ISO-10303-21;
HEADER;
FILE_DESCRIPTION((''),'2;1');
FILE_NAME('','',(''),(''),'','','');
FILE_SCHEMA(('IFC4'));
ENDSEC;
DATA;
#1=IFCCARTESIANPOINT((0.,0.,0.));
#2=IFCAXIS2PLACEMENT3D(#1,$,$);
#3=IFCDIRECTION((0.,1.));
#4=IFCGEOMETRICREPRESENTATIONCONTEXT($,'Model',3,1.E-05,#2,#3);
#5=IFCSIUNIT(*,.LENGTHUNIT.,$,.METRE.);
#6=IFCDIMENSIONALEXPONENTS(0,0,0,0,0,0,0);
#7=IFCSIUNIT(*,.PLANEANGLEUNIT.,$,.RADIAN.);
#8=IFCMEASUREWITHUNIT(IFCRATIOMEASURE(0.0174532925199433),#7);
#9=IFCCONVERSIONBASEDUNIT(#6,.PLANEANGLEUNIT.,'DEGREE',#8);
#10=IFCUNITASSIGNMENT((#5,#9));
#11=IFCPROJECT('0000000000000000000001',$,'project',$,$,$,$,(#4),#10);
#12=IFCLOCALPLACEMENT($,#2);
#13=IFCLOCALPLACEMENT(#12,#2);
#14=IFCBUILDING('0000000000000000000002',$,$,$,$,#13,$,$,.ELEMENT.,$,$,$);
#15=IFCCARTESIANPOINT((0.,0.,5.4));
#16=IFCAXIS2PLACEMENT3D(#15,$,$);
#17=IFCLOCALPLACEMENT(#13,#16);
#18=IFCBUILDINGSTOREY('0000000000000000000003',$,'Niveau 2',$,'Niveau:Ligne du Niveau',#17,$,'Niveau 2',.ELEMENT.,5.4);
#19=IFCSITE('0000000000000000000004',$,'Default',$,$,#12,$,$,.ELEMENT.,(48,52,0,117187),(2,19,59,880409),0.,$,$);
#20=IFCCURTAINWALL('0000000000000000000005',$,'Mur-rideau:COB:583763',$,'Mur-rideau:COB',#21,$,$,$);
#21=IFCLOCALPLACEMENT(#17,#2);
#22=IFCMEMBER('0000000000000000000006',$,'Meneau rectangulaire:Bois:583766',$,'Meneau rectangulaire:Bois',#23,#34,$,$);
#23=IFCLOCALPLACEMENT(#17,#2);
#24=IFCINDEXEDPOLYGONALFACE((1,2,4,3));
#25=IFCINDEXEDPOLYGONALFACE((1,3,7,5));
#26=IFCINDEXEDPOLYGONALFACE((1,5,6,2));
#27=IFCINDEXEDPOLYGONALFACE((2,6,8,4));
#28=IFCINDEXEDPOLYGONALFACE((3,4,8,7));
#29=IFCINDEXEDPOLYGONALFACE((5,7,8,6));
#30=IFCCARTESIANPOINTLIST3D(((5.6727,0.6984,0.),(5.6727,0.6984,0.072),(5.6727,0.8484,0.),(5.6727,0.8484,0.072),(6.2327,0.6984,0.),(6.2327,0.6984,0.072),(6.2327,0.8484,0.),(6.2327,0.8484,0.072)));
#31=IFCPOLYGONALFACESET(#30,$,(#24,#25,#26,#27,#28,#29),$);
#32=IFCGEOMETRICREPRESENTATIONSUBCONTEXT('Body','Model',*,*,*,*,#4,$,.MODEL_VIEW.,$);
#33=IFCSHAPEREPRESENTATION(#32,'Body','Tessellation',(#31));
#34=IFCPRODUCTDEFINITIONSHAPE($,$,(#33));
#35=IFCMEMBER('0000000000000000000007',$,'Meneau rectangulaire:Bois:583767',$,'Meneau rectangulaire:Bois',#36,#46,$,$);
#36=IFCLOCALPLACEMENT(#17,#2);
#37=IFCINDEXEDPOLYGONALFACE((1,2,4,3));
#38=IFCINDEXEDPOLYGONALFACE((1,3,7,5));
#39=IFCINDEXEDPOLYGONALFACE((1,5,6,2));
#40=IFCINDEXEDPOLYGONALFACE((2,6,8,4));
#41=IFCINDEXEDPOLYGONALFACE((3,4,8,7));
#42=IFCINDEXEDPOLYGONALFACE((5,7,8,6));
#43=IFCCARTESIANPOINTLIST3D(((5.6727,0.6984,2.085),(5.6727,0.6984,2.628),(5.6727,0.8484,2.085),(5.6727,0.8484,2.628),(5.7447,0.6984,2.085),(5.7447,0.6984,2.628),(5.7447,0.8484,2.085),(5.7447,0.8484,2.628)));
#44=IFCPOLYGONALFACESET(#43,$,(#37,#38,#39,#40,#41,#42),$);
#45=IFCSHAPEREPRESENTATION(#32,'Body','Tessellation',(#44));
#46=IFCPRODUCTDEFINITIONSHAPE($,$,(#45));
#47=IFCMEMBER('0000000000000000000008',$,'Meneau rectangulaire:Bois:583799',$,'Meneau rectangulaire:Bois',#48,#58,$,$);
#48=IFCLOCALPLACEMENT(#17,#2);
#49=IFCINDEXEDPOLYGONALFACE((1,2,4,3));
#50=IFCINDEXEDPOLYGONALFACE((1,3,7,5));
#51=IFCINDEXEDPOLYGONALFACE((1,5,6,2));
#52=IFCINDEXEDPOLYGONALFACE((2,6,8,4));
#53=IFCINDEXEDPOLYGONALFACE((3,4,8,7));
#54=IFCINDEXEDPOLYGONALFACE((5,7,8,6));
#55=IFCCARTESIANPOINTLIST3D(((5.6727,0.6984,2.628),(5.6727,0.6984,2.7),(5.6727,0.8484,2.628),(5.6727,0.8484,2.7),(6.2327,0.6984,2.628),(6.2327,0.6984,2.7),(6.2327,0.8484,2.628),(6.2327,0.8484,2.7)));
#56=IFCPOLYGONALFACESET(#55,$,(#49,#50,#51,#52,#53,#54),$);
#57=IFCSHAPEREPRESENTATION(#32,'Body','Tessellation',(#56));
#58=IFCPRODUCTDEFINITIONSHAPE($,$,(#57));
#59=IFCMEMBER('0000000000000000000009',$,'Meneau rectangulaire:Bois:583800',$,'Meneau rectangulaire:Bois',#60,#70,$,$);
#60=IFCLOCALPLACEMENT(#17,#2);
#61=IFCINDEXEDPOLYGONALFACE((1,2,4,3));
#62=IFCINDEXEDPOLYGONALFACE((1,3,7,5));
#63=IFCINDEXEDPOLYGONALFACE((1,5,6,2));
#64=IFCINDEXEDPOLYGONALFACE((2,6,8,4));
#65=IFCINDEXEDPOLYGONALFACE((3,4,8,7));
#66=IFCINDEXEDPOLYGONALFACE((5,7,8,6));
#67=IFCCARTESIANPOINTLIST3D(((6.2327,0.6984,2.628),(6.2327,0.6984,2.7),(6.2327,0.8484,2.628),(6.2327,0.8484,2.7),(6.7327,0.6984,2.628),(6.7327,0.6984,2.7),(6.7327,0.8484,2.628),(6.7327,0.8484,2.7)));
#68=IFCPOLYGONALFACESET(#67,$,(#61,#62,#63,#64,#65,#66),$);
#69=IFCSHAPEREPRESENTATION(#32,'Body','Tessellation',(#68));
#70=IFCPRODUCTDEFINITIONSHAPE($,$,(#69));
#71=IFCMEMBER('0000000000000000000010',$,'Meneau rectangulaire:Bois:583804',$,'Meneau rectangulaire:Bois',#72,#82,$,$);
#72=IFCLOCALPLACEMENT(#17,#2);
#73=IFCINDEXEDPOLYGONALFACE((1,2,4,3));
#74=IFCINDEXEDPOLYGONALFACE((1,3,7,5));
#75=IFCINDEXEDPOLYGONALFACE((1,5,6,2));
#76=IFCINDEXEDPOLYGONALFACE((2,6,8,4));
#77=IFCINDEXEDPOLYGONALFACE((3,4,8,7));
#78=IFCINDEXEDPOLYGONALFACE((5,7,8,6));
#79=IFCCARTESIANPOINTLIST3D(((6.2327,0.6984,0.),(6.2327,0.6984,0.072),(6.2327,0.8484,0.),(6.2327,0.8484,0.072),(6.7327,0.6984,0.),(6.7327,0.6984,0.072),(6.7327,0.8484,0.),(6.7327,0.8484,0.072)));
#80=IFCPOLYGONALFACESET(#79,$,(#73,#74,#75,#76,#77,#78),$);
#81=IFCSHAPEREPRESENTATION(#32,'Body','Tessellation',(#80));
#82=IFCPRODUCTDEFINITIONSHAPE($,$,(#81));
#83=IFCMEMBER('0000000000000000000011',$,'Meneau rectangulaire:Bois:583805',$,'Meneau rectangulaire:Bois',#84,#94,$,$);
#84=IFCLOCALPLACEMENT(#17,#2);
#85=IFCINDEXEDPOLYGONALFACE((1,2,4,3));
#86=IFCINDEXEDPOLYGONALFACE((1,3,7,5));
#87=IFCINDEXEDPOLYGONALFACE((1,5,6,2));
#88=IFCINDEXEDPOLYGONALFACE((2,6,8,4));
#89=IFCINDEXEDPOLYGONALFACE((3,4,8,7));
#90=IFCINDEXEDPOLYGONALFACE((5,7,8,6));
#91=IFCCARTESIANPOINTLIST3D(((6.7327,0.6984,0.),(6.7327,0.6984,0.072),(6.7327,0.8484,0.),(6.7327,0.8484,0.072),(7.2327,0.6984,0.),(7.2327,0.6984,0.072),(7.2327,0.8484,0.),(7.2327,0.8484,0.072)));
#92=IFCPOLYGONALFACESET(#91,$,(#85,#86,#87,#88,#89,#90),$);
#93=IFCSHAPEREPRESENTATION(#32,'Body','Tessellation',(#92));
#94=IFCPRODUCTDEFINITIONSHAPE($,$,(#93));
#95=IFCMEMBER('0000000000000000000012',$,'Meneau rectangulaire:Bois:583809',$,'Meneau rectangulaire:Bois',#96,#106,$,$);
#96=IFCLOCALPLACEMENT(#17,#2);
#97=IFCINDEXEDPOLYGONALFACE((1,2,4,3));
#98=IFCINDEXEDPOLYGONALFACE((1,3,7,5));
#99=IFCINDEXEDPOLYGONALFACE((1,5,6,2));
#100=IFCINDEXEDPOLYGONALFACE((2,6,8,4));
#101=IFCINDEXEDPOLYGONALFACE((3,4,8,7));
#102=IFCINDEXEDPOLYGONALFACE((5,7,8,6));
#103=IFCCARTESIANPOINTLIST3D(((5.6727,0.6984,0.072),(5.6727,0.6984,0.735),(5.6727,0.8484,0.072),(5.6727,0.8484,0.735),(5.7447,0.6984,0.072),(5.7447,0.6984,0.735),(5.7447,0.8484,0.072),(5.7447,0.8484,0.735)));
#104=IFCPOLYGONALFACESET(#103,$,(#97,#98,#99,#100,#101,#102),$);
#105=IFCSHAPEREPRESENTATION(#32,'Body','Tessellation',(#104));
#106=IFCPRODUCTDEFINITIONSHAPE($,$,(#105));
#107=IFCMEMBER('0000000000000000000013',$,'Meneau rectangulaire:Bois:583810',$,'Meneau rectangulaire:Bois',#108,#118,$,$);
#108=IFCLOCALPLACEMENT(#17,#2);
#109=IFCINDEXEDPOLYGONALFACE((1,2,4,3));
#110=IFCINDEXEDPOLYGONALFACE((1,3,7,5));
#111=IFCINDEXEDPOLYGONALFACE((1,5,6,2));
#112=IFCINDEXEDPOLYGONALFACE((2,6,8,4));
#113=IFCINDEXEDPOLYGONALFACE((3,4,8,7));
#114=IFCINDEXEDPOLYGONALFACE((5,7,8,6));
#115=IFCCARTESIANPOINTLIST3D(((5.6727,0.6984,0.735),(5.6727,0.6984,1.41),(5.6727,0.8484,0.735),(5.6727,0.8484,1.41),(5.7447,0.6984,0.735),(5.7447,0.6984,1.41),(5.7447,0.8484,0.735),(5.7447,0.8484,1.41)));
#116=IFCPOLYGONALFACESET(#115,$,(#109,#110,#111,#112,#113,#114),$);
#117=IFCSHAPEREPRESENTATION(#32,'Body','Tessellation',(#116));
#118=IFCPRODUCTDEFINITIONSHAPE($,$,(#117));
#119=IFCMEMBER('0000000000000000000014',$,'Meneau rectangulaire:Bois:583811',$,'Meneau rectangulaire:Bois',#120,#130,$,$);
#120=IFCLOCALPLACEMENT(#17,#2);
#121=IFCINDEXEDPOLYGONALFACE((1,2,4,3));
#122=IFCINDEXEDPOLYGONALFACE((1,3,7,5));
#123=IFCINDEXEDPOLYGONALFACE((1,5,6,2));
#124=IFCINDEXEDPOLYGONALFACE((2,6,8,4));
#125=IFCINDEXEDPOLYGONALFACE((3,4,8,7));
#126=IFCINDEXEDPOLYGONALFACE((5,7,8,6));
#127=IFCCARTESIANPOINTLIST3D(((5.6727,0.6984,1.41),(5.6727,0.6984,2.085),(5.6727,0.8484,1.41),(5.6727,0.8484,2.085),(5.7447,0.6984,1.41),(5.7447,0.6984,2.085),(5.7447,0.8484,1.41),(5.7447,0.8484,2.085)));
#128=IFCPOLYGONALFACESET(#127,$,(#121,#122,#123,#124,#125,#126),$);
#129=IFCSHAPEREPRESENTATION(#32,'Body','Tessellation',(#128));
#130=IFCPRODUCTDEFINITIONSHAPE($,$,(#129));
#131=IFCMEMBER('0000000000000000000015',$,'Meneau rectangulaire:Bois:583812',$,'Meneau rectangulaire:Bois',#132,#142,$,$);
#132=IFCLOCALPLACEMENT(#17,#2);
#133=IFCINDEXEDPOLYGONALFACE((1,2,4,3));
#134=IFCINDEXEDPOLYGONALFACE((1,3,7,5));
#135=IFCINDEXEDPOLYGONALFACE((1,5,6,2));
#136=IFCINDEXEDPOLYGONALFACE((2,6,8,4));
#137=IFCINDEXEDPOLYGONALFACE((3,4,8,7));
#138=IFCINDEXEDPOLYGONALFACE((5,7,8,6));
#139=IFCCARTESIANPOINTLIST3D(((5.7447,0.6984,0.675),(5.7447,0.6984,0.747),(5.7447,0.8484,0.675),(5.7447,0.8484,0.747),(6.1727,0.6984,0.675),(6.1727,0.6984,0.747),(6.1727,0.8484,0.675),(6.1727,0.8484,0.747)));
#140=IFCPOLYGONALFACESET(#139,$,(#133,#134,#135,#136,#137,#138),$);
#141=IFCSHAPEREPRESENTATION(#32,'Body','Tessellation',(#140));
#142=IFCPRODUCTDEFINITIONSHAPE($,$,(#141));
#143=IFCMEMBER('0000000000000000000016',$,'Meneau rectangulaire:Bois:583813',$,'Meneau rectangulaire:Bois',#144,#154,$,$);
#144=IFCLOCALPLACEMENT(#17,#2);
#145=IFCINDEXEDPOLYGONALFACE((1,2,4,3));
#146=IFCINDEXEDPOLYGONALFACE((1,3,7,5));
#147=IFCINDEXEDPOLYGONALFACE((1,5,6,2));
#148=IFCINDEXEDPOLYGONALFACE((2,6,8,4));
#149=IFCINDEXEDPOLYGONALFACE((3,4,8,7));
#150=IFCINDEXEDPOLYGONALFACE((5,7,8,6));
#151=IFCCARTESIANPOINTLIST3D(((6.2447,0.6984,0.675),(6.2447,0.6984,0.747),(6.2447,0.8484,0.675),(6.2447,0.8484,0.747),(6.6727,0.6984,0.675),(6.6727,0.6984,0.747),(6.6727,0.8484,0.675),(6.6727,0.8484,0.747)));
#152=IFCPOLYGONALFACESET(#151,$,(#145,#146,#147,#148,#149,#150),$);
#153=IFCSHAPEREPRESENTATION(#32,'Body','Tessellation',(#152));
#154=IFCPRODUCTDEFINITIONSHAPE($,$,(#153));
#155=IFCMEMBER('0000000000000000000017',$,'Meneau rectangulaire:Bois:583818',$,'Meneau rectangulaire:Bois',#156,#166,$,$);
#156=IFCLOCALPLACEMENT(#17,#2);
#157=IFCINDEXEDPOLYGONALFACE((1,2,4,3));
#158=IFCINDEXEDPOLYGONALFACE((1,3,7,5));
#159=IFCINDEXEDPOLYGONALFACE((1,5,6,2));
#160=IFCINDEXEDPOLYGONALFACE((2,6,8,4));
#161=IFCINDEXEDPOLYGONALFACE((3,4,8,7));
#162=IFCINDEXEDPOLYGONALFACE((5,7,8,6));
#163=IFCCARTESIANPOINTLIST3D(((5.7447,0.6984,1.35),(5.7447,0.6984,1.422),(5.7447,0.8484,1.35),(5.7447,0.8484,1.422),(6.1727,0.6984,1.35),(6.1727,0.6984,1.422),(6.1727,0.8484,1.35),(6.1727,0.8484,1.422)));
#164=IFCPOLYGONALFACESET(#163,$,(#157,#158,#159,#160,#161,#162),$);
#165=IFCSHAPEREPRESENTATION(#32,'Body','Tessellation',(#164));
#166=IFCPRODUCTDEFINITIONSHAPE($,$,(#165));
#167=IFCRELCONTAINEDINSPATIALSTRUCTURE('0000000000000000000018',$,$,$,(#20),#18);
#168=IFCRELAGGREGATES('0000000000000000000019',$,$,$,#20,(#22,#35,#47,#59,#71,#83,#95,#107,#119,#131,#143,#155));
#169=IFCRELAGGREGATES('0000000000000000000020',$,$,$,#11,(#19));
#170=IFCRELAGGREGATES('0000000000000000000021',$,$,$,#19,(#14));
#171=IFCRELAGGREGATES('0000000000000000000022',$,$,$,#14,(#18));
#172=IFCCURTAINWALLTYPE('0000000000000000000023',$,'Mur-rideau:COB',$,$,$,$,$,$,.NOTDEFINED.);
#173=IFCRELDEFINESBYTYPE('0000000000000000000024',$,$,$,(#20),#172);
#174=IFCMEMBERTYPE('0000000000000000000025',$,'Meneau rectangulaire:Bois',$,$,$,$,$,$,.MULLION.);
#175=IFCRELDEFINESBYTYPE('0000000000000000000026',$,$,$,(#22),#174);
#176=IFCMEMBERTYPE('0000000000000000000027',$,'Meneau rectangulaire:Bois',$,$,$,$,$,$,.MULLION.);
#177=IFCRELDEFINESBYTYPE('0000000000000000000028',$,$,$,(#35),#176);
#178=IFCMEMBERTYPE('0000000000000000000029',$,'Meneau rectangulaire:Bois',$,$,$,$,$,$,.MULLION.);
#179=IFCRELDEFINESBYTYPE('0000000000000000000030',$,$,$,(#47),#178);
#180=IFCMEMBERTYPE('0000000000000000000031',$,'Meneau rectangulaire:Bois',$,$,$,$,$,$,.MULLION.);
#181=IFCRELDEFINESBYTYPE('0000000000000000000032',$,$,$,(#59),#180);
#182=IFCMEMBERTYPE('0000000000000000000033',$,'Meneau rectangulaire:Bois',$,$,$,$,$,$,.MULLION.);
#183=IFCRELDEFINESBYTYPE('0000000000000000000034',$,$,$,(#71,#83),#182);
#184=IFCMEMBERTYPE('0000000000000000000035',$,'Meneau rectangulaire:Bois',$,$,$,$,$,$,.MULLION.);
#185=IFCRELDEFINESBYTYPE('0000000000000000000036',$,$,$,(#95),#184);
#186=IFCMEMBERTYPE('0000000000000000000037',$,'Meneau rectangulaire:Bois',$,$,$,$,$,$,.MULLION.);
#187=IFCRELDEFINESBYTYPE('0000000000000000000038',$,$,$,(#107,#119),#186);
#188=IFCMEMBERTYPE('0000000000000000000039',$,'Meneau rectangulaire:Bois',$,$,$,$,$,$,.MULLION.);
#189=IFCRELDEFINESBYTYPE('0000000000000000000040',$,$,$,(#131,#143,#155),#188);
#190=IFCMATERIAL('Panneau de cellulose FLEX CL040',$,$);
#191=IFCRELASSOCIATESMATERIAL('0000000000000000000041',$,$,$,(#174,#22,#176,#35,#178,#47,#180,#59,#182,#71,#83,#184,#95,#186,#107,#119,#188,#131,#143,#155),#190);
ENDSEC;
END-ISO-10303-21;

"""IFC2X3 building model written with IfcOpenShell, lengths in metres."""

from ifc_helpers import new_model, entity, si_unit, converted_unit, direction, frame, origin, origin_2d_with_axis, place, context, subcontext, project, spatial, rectangle, extrude, source, transform, mapped, material, type_object, type_shapes, element, aggregate, save


model = new_model("IFC2X3")

# Units and contexts
model_context = context("Model", 3, precision=1e-05, world=origin(), true_north=direction((0.0, 1.0)))
body_context = subcontext(model_context, "Body", "Model", "MODEL_VIEW")
ifc_project = project(units=[si_unit("LENGTHUNIT", "METRE"), converted_unit("PLANEANGLEUNIT", "DEGREE", entity("IfcRatioMeasure", 0.0174532925199433), si_unit("PLANEANGLEUNIT", "RADIAN"), dimensions=[0, 0, 0, 0, 0, 0, 0])], contexts=[model_context])

# Site, building, storey
site_placement = place(None, origin())
site = spatial("IfcSite", under=ifc_project, at=site_placement, Name="Default", CompositionType="ELEMENT", RefLatitude=(48, 52, 0, 117187), RefLongitude=(2, 19, 59, 880409), RefElevation=0.0)
building_placement = place(site_placement, origin())
building = spatial("IfcBuilding", under=site, at=building_placement, CompositionType="ELEMENT")
storey_placement = place(building_placement, frame((0.0, 0.0, 5.4)))
storey = spatial("IfcBuildingStorey", under=building, at=storey_placement, Name="Niveau 2", ObjectType="Niveau:Ligne du Niveau", LongName="Niveau 2", CompositionType="ELEMENT", Elevation=5.4)

# Curtain wall, members
curtain_wall_type_1 = type_object("IfcCurtainWallType", Name="Mur-rideau:COB", PredefinedType="NOTDEFINED")
curtain_wall_1_placement = place(storey_placement, frame((0.0, 0.0, -5.4)))
curtain_wall_1 = element("IfcCurtainWall", 1, at=curtain_wall_1_placement, inside=storey, type_object=curtain_wall_type_1, Name="Mur-rideau:COB:583763", ObjectType="Mur-rideau:COB")
ifc_material_1 = material(Name="Panneau de cellulose FLEX CL040")
member_type_1 = type_object("IfcMemberType", Name="Meneau rectangulaire:Bois", PredefinedType="MULLION", material=ifc_material_1)
shared_shape_1 = source(origin(), body_context, "Body", "SweptSolid", [
    extrude(rectangle(XDim=0.15, YDim=0.072, at=origin_2d_with_axis()), frame((-0.036, 0.0, -0.56), z_axis=(0.0, 0.0, 1.0), x_axis=(0.0, -1.0, 0.0)), (0.0, 0.0, 1.0), 0.56),
])
type_shapes(member_type_1, [shared_shape_1])
member_1_placement = place(storey_placement, frame((5.6727, 0.7734, 0.0), z_axis=(-1.0, 0.0, 0.0), x_axis=(0.0, 0.0, -1.0)))
member_1 = element("IfcMember", 2, at=member_1_placement, type_object=member_type_1, material=ifc_material_1, Name="Meneau rectangulaire:Bois:583766", ObjectType="Meneau rectangulaire:Bois", context=body_context, shape_type="MappedRepresentation", body=[
    mapped(shared_shape_1, transform((0.0, 0.0, 0.0), scale=1.0)),
])
member_type_2 = type_object("IfcMemberType", Name="Meneau rectangulaire:Bois", PredefinedType="MULLION", material=ifc_material_1)
shared_shape_2 = source(origin(), body_context, "Body", "SweptSolid", [
    extrude(rectangle(XDim=0.15, YDim=0.072, at=origin_2d_with_axis()), frame((-0.036, 0.0, -0.543), z_axis=(0.0, 0.0, 1.0), x_axis=(0.0, -1.0, 0.0)), (0.0, 0.0, 1.0), 0.543),
])
type_shapes(member_type_2, [shared_shape_2])
member_2_placement = place(storey_placement, frame((5.6727, 0.7734, 2.628), z_axis=(0.0, 0.0, 1.0), x_axis=(-1.0, 0.0, 0.0)))
member_2 = element("IfcMember", 3, at=member_2_placement, type_object=member_type_2, material=ifc_material_1, Name="Meneau rectangulaire:Bois:583767", ObjectType="Meneau rectangulaire:Bois", context=body_context, shape_type="MappedRepresentation", body=[
    mapped(shared_shape_2, transform((0.0, 0.0, 0.0), scale=1.0)),
])
member_type_3 = type_object("IfcMemberType", Name="Meneau rectangulaire:Bois", PredefinedType="MULLION", material=ifc_material_1)
shared_shape_3 = source(origin(), body_context, "Body", "SweptSolid", [
    extrude(rectangle(XDim=0.15, YDim=0.072, at=origin_2d_with_axis()), frame((-0.036, 0.0, -0.56), z_axis=(0.0, 0.0, 1.0), x_axis=(0.0, -1.0, 0.0)), (0.0, 0.0, 1.0), 0.56),
])
type_shapes(member_type_3, [shared_shape_3])
member_3_placement = place(storey_placement, frame((6.2327, 0.7734, 2.7), z_axis=(1.0, 0.0, 0.0), x_axis=(0.0, 0.0, 1.0)))
member_3 = element("IfcMember", 4, at=member_3_placement, type_object=member_type_3, material=ifc_material_1, Name="Meneau rectangulaire:Bois:583799", ObjectType="Meneau rectangulaire:Bois", context=body_context, shape_type="MappedRepresentation", body=[
    mapped(shared_shape_3, transform((0.0, 0.0, 0.0), scale=1.0)),
])
member_type_4 = type_object("IfcMemberType", Name="Meneau rectangulaire:Bois", PredefinedType="MULLION", material=ifc_material_1)
shared_shape_4 = source(origin(), body_context, "Body", "SweptSolid", [
    extrude(rectangle(XDim=0.15, YDim=0.072, at=origin_2d_with_axis()), frame((-0.036, 0.0, -0.5), z_axis=(0.0, 0.0, 1.0), x_axis=(0.0, -1.0, 0.0)), (0.0, 0.0, 1.0), 0.5),
])
type_shapes(member_type_4, [shared_shape_4])
member_4_placement = place(storey_placement, frame((6.7327, 0.7734, 2.7), z_axis=(1.0, 0.0, 0.0), x_axis=(0.0, 0.0, 1.0)))
member_4 = element("IfcMember", 5, at=member_4_placement, type_object=member_type_4, material=ifc_material_1, Name="Meneau rectangulaire:Bois:583800", ObjectType="Meneau rectangulaire:Bois", context=body_context, shape_type="MappedRepresentation", body=[
    mapped(shared_shape_4, transform((0.0, 0.0, 0.0), scale=1.0)),
])
member_type_5 = type_object("IfcMemberType", Name="Meneau rectangulaire:Bois", PredefinedType="MULLION", material=ifc_material_1)
shared_shape_5 = source(origin(), body_context, "Body", "SweptSolid", [
    extrude(rectangle(XDim=0.15, YDim=0.072, at=origin_2d_with_axis()), frame((-0.036, 0.0, -0.5), z_axis=(0.0, 0.0, 1.0), x_axis=(0.0, -1.0, 0.0)), (0.0, 0.0, 1.0), 0.5),
])
type_shapes(member_type_5, [shared_shape_5])
member_5_placement = place(storey_placement, frame((6.2327, 0.7734, 0.0), z_axis=(-1.0, 0.0, 0.0), x_axis=(0.0, 0.0, -1.0)))
member_5 = element("IfcMember", 6, at=member_5_placement, type_object=member_type_5, material=ifc_material_1, Name="Meneau rectangulaire:Bois:583804", ObjectType="Meneau rectangulaire:Bois", context=body_context, shape_type="MappedRepresentation", body=[
    mapped(shared_shape_5, transform((0.0, 0.0, 0.0), scale=1.0)),
])
member_6_placement = place(storey_placement, frame((6.7327, 0.7734, 0.0), z_axis=(-1.0, 0.0, 0.0), x_axis=(0.0, 0.0, -1.0)))
member_6 = element("IfcMember", 7, at=member_6_placement, type_object=member_type_5, material=ifc_material_1, Name="Meneau rectangulaire:Bois:583805", ObjectType="Meneau rectangulaire:Bois", context=body_context, shape_type="MappedRepresentation", body=[
    mapped(shared_shape_5, transform((0.0, 0.0, 0.0), scale=1.0)),
])
member_type_6 = type_object("IfcMemberType", Name="Meneau rectangulaire:Bois", PredefinedType="MULLION", material=ifc_material_1)
shared_shape_6 = source(origin(), body_context, "Body", "SweptSolid", [
    extrude(rectangle(XDim=0.15, YDim=0.072, at=origin_2d_with_axis()), frame((-0.036, 0.0, -0.663), z_axis=(0.0, 0.0, 1.0), x_axis=(0.0, -1.0, 0.0)), (0.0, 0.0, 1.0), 0.663),
])
type_shapes(member_type_6, [shared_shape_6])
member_7_placement = place(storey_placement, frame((5.6727, 0.7734, 0.735), z_axis=(0.0, 0.0, 1.0), x_axis=(-1.0, 0.0, 0.0)))
member_7 = element("IfcMember", 8, at=member_7_placement, type_object=member_type_6, material=ifc_material_1, Name="Meneau rectangulaire:Bois:583809", ObjectType="Meneau rectangulaire:Bois", context=body_context, shape_type="MappedRepresentation", body=[
    mapped(shared_shape_6, transform((0.0, 0.0, 0.0), scale=1.0)),
])
member_type_7 = type_object("IfcMemberType", Name="Meneau rectangulaire:Bois", PredefinedType="MULLION", material=ifc_material_1)
shared_shape_7 = source(origin(), body_context, "Body", "SweptSolid", [
    extrude(rectangle(XDim=0.15, YDim=0.072, at=origin_2d_with_axis()), frame((-0.036, 0.0, -0.675), z_axis=(0.0, 0.0, 1.0), x_axis=(0.0, -1.0, 0.0)), (0.0, 0.0, 1.0), 0.675),
])
type_shapes(member_type_7, [shared_shape_7])
member_8_placement = place(storey_placement, frame((5.6727, 0.7734, 1.41), z_axis=(0.0, 0.0, 1.0), x_axis=(-1.0, 0.0, 0.0)))
member_8 = element("IfcMember", 9, at=member_8_placement, type_object=member_type_7, material=ifc_material_1, Name="Meneau rectangulaire:Bois:583810", ObjectType="Meneau rectangulaire:Bois", context=body_context, shape_type="MappedRepresentation", body=[
    mapped(shared_shape_7, transform((0.0, 0.0, 0.0), scale=1.0)),
])
member_9_placement = place(storey_placement, frame((5.6727, 0.7734, 2.085), z_axis=(0.0, 0.0, 1.0), x_axis=(-1.0, 0.0, 0.0)))
member_9 = element("IfcMember", 10, at=member_9_placement, type_object=member_type_7, material=ifc_material_1, Name="Meneau rectangulaire:Bois:583811", ObjectType="Meneau rectangulaire:Bois", context=body_context, shape_type="MappedRepresentation", body=[
    mapped(shared_shape_7, transform((0.0, 0.0, 0.0), scale=1.0)),
])
member_type_8 = type_object("IfcMemberType", Name="Meneau rectangulaire:Bois", PredefinedType="MULLION", material=ifc_material_1)
shared_shape_8 = source(origin(), body_context, "Body", "SweptSolid", [
    extrude(rectangle(XDim=0.15, YDim=0.072, at=origin_2d_with_axis()), frame((-0.024, 0.0, -0.428), z_axis=(0.0, 0.0, 1.0), x_axis=(0.0, -1.0, 0.0)), (0.0, 0.0, 1.0), 0.428),
])
type_shapes(member_type_8, [shared_shape_8])
member_10_placement = place(storey_placement, frame((6.1727, 0.7734, 0.735), z_axis=(1.0, 0.0, 0.0), x_axis=(0.0, 0.0, 1.0)))
member_10 = element("IfcMember", 11, at=member_10_placement, type_object=member_type_8, material=ifc_material_1, Name="Meneau rectangulaire:Bois:583812", ObjectType="Meneau rectangulaire:Bois", context=body_context, shape_type="MappedRepresentation", body=[
    mapped(shared_shape_8, transform((0.0, 0.0, 0.0), scale=1.0)),
])
member_11_placement = place(storey_placement, frame((6.6727, 0.7734, 0.735), z_axis=(1.0, 0.0, 0.0), x_axis=(0.0, 0.0, 1.0)))
member_11 = element("IfcMember", 12, at=member_11_placement, type_object=member_type_8, material=ifc_material_1, Name="Meneau rectangulaire:Bois:583813", ObjectType="Meneau rectangulaire:Bois", context=body_context, shape_type="MappedRepresentation", body=[
    mapped(shared_shape_8, transform((0.0, 0.0, 0.0), scale=1.0)),
])
member_12_placement = place(storey_placement, frame((6.1727, 0.7734, 1.41), z_axis=(1.0, 0.0, 0.0), x_axis=(0.0, 0.0, 1.0)))
member_12 = element("IfcMember", 13, at=member_12_placement, type_object=member_type_8, material=ifc_material_1, Name="Meneau rectangulaire:Bois:583818", ObjectType="Meneau rectangulaire:Bois", context=body_context, shape_type="MappedRepresentation", body=[
    mapped(shared_shape_8, transform((0.0, 0.0, 0.0), scale=1.0)),
])
aggregate(curtain_wall_1, [member_1, member_2, member_3, member_4, member_5, member_6, member_7, member_8, member_9, member_10, member_11, member_12])

save(model, "model.ifc")
